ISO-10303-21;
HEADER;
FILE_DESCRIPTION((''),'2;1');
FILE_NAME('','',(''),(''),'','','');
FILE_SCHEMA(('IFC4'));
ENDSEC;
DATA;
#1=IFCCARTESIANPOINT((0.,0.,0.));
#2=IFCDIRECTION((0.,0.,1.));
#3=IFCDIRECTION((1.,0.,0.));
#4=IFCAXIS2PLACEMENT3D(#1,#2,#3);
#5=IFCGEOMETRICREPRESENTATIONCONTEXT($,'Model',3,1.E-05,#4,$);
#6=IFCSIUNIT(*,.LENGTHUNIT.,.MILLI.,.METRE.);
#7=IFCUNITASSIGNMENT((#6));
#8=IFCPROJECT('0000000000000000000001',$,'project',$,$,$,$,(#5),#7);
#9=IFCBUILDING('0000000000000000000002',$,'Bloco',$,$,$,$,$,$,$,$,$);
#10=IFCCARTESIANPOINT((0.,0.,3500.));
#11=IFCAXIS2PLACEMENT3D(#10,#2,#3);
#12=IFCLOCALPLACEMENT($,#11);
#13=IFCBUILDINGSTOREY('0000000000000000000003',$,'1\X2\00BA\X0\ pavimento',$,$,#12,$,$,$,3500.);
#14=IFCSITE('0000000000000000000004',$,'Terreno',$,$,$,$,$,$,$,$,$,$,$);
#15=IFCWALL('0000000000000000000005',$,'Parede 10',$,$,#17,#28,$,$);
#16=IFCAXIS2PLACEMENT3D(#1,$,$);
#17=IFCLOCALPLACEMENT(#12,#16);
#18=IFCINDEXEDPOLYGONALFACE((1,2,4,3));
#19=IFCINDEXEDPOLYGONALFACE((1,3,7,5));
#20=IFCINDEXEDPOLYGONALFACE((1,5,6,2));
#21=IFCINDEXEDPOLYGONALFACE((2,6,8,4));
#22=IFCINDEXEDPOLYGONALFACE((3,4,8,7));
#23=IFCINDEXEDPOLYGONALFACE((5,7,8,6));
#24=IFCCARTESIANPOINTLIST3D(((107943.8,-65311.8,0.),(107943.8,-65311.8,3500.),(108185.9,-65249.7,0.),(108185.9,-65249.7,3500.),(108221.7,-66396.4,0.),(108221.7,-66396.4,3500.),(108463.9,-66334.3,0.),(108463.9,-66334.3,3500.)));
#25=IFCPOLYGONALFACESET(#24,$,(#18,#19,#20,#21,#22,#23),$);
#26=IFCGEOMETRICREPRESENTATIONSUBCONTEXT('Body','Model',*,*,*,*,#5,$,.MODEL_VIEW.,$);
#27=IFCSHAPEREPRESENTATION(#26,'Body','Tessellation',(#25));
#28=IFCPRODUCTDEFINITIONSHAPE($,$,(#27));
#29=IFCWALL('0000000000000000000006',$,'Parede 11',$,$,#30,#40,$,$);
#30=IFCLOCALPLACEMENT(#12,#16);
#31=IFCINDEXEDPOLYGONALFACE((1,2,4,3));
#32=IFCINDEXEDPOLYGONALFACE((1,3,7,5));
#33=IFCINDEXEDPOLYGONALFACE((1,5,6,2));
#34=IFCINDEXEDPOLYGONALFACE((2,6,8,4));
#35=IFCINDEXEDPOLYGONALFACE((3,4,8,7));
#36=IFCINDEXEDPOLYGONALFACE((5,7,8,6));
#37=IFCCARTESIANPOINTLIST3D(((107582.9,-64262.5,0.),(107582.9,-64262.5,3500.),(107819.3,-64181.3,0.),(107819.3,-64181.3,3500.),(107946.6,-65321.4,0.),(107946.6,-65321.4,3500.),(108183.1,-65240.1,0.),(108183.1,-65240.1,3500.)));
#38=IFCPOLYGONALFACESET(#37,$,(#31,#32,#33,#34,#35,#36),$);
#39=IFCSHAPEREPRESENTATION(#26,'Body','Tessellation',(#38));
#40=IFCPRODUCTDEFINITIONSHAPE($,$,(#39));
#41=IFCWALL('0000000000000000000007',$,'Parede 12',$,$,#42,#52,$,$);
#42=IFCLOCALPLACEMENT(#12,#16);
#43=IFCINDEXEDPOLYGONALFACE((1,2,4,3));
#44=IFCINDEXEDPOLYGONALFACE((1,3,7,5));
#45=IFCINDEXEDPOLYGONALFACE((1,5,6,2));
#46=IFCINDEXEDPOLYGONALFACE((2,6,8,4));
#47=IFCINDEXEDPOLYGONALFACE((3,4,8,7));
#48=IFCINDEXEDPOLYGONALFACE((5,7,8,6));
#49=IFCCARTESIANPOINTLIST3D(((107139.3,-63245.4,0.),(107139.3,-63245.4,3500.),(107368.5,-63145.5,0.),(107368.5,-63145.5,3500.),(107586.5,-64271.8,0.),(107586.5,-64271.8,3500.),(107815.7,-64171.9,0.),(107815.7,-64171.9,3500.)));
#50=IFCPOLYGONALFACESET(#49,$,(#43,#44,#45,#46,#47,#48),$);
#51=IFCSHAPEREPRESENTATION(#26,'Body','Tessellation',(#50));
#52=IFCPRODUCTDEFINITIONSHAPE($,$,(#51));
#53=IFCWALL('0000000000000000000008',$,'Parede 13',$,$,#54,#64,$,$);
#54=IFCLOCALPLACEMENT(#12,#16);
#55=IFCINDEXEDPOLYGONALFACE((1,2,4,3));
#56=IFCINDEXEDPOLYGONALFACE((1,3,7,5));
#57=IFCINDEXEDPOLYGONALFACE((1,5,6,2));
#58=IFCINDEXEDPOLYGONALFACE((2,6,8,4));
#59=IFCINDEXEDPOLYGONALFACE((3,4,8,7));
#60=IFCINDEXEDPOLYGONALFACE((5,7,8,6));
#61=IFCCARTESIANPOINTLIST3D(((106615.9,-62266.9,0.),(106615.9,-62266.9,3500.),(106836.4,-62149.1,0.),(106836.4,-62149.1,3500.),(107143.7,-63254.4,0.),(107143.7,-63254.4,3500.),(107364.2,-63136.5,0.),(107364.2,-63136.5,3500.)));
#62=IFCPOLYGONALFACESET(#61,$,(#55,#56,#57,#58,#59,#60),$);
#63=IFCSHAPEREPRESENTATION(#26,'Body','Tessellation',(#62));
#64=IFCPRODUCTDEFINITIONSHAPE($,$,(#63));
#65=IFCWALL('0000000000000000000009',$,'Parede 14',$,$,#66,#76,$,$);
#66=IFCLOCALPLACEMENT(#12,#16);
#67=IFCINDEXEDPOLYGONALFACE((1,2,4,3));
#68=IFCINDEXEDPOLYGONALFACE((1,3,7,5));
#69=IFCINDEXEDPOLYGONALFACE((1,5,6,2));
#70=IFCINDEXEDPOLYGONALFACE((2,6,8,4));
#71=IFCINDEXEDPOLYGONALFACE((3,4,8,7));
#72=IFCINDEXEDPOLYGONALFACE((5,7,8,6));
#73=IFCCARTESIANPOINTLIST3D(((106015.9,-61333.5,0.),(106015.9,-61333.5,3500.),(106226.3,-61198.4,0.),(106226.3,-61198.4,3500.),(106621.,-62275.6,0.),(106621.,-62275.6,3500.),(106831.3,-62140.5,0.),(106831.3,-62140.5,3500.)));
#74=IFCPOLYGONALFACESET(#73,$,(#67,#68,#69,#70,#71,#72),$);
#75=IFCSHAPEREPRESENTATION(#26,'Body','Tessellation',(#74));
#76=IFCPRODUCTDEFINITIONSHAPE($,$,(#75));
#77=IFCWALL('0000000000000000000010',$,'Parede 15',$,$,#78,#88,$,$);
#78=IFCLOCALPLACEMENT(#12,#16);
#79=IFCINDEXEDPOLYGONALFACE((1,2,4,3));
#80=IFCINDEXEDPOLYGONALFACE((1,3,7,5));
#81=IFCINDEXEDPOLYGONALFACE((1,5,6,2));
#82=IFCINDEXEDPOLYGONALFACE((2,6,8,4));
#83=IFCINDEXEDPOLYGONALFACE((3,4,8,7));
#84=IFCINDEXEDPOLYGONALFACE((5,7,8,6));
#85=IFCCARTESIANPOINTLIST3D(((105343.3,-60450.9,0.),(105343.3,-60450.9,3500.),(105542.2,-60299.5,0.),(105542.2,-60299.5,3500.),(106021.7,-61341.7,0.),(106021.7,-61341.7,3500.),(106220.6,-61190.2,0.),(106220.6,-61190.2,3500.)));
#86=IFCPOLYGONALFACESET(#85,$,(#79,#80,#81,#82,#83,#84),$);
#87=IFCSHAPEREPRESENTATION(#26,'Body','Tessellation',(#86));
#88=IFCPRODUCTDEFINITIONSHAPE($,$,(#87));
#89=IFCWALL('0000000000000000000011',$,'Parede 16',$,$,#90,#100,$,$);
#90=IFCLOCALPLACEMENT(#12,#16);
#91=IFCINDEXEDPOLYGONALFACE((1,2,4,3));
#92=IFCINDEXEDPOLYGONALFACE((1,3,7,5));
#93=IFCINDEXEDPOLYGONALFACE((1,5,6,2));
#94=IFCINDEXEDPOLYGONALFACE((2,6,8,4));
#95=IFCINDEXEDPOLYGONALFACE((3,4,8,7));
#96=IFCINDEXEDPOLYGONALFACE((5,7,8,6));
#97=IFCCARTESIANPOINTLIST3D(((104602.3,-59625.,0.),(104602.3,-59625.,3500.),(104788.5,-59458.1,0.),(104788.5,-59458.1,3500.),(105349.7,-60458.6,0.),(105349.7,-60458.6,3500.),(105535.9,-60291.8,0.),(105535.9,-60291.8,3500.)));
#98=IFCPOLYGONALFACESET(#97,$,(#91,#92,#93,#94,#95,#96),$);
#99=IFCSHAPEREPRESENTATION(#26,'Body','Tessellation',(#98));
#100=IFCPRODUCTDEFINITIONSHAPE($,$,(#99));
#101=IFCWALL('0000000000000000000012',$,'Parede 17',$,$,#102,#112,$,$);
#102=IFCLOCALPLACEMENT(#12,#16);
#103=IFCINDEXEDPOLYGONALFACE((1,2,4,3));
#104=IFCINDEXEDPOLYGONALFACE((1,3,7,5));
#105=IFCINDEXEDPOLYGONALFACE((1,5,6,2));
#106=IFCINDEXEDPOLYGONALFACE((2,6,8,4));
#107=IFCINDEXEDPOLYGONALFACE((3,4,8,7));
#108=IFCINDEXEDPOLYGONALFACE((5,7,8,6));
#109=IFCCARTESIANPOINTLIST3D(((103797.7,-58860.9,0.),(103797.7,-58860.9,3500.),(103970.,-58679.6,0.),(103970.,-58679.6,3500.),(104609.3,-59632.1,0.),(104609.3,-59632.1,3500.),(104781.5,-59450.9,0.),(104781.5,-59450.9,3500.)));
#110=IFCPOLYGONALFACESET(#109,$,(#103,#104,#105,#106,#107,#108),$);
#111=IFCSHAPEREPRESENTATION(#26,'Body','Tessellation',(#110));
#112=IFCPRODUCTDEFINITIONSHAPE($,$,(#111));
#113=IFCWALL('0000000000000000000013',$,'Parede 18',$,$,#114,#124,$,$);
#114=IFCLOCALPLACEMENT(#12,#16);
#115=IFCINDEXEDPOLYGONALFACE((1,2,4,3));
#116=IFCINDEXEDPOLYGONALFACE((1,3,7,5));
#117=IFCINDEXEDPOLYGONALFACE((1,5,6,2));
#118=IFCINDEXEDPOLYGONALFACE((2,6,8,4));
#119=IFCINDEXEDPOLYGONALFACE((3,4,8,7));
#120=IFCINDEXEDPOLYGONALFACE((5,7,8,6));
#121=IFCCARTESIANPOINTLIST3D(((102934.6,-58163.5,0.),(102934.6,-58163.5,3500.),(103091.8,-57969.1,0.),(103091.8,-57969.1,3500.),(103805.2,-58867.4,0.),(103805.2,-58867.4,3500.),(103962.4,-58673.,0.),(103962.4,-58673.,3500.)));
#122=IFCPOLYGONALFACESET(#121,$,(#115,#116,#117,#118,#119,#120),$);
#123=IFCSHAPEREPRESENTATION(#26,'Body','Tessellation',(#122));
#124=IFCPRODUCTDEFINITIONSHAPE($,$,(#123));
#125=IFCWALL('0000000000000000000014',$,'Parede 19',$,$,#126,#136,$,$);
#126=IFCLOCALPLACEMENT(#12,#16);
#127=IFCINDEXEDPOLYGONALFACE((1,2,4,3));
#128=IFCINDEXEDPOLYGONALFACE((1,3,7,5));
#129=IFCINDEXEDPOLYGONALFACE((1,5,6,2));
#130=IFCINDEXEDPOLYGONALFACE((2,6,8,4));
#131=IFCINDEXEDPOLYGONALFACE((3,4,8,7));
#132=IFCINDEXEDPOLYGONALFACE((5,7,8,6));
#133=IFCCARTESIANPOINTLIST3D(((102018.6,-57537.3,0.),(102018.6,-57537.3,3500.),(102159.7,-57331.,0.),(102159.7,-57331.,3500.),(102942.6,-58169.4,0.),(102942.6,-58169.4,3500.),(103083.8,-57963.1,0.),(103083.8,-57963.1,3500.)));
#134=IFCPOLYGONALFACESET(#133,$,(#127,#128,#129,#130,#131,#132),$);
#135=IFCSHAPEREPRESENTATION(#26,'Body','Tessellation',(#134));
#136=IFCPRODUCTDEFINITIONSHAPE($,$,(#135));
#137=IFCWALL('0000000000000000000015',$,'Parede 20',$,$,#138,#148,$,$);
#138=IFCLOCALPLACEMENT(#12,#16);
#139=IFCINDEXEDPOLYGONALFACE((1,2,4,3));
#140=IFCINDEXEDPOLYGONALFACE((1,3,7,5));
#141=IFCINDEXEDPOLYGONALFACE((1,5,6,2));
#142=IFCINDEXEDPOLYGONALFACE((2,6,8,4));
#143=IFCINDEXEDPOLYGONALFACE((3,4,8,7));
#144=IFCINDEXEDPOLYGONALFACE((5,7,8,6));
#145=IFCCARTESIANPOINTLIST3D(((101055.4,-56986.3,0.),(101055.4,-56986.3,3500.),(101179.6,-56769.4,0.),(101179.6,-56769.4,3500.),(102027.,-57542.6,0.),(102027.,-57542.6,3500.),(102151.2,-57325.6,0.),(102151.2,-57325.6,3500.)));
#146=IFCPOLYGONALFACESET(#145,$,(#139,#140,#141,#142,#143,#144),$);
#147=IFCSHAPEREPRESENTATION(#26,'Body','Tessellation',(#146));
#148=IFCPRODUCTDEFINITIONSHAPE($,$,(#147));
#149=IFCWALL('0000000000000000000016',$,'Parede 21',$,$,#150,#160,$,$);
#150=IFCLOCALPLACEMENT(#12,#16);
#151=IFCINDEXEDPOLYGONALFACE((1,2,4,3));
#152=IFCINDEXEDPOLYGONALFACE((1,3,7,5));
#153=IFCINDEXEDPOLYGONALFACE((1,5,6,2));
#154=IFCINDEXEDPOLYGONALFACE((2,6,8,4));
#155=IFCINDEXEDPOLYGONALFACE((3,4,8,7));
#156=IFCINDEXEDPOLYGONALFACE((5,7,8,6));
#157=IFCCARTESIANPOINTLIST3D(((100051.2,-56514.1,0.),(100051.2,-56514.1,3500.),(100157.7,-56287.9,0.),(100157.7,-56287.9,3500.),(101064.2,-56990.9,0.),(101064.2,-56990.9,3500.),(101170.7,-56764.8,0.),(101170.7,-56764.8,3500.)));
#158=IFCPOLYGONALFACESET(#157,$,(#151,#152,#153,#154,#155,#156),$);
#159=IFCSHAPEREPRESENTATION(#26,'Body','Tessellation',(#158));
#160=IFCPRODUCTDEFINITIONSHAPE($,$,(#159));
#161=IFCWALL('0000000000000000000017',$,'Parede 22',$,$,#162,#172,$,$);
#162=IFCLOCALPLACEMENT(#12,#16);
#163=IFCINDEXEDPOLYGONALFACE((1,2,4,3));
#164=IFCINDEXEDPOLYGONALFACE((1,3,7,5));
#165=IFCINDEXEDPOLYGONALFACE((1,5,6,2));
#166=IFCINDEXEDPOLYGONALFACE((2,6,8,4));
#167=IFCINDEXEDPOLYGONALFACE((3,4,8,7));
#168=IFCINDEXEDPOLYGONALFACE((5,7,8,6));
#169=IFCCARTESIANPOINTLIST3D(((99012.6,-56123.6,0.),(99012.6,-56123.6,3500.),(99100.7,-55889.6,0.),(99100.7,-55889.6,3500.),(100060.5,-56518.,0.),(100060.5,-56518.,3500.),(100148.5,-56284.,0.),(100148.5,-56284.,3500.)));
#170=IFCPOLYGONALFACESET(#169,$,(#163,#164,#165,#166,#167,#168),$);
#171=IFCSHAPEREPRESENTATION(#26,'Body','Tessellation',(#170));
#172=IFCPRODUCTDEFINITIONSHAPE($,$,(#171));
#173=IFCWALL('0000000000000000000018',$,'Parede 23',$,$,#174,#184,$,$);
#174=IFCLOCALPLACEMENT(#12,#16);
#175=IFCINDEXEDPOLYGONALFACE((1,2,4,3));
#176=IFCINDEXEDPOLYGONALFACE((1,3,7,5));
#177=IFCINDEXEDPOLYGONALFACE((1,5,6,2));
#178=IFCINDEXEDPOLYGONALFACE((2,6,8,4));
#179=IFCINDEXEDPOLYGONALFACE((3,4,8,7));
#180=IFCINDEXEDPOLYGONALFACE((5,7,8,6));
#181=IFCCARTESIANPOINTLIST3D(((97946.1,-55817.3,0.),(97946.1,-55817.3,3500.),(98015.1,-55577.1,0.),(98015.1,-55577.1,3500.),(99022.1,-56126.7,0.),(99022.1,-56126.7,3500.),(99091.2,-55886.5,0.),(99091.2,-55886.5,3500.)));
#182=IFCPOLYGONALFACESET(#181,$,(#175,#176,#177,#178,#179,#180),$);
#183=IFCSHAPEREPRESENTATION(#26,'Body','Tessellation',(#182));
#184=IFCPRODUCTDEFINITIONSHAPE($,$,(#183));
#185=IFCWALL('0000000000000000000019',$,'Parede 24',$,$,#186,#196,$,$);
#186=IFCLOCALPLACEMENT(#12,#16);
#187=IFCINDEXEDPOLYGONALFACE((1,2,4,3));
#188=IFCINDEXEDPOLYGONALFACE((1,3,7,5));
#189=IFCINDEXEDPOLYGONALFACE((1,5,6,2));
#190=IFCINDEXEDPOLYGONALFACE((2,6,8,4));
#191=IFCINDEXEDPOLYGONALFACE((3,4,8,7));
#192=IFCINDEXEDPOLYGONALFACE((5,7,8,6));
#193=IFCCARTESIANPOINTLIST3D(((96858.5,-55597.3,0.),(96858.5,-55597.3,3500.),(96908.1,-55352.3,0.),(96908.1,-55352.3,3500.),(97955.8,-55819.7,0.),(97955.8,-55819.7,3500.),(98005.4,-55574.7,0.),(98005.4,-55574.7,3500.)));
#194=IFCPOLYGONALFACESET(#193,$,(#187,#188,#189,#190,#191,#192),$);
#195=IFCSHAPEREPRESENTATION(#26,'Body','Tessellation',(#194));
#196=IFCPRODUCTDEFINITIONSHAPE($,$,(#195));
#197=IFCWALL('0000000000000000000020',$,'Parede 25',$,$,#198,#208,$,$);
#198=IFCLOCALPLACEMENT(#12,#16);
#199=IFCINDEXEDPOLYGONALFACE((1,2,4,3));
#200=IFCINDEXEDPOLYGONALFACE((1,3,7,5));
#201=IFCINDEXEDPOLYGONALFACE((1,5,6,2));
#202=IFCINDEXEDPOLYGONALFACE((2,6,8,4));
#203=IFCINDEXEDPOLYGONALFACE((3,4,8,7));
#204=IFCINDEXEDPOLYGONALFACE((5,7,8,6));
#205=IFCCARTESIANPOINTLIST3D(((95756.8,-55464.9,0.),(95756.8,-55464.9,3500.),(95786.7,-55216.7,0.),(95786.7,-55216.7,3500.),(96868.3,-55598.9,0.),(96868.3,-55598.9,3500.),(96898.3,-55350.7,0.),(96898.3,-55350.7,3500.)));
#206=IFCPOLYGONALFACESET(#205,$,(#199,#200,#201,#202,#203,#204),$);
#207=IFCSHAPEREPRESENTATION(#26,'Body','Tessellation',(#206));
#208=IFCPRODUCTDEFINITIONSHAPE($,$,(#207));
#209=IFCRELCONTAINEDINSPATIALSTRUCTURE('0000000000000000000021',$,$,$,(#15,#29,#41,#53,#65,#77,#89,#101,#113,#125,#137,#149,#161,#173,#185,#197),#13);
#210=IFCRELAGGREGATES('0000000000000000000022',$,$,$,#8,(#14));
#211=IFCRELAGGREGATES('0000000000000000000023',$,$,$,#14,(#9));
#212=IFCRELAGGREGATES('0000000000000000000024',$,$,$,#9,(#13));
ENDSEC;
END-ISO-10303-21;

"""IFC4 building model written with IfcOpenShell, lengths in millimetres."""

from ifc_helpers import new_model, si_unit, frame, origin, origin_with_axes, place, context, subcontext, project, spatial, polyline, outline, extrude, element, save


model = new_model("IFC4")

# Units and contexts
model_context = context("Model", 3, precision=1e-05, world=origin_with_axes())
body_context = subcontext(model_context, "Body", "Model", "MODEL_VIEW")
ifc_project = project(units=[si_unit("LENGTHUNIT", "METRE", prefix="MILLI")], contexts=[model_context])

# Site, building, storey
site = spatial("IfcSite", under=ifc_project, Name="Terreno")
building = spatial("IfcBuilding", under=site, Name="Bloco")
storey_placement = place(None, frame((0.0, 0.0, 3500.0), z_axis=(0.0, 0.0, 1.0), x_axis=(1.0, 0.0, 0.0)))
storey = spatial("IfcBuildingStorey", under=building, at=storey_placement, Name="1º pavimento", Elevation=3500.0)

# Walls
wall_1_placement = place(storey_placement, origin_with_axes())
element("IfcWall", 1, at=wall_1_placement, inside=storey, Name="Parede 10", context=body_context, shape_type="SweptSolid", body=[
    extrude(outline(polyline([(108221.7, -66396.4), (107943.8, -65311.8), (108185.9, -65249.7), (108463.9, -66334.3), (108221.7, -66396.4)])), origin(), (0.0, 0.0, 1.0), 3500.0),
])
wall_2_placement = place(storey_placement, origin_with_axes())
element("IfcWall", 2, at=wall_2_placement, inside=storey, Name="Parede 11", context=body_context, shape_type="SweptSolid", body=[
    extrude(outline(polyline([(107946.6, -65321.4), (107582.9, -64262.5), (107819.3, -64181.3), (108183.1, -65240.1), (107946.6, -65321.4)])), origin(), (0.0, 0.0, 1.0), 3500.0),
])
wall_3_placement = place(storey_placement, origin_with_axes())
element("IfcWall", 3, at=wall_3_placement, inside=storey, Name="Parede 12", context=body_context, shape_type="SweptSolid", body=[
    extrude(outline(polyline([(107586.5, -64271.8), (107139.3, -63245.4), (107368.5, -63145.5), (107815.7, -64171.9), (107586.5, -64271.8)])), origin(), (0.0, 0.0, 1.0), 3500.0),
])
wall_4_placement = place(storey_placement, origin_with_axes())
element("IfcWall", 4, at=wall_4_placement, inside=storey, Name="Parede 13", context=body_context, shape_type="SweptSolid", body=[
    extrude(outline(polyline([(107143.7, -63254.4), (106615.9, -62266.9), (106836.4, -62149.1), (107364.2, -63136.5), (107143.7, -63254.4)])), origin(), (0.0, 0.0, 1.0), 3500.0),
])
wall_5_placement = place(storey_placement, origin_with_axes())
element("IfcWall", 5, at=wall_5_placement, inside=storey, Name="Parede 14", context=body_context, shape_type="SweptSolid", body=[
    extrude(outline(polyline([(106621.0, -62275.6), (106015.9, -61333.5), (106226.3, -61198.4), (106831.3, -62140.5), (106621.0, -62275.6)])), origin(), (0.0, 0.0, 1.0), 3500.0),
])
wall_6_placement = place(storey_placement, origin_with_axes())
element("IfcWall", 6, at=wall_6_placement, inside=storey, Name="Parede 15", context=body_context, shape_type="SweptSolid", body=[
    extrude(outline(polyline([(106021.7, -61341.7), (105343.3, -60450.9), (105542.2, -60299.5), (106220.6, -61190.2), (106021.7, -61341.7)])), origin(), (0.0, 0.0, 1.0), 3500.0),
])
wall_7_placement = place(storey_placement, origin_with_axes())
element("IfcWall", 7, at=wall_7_placement, inside=storey, Name="Parede 16", context=body_context, shape_type="SweptSolid", body=[
    extrude(outline(polyline([(105349.7, -60458.6), (104602.3, -59625.0), (104788.5, -59458.1), (105535.9, -60291.8), (105349.7, -60458.6)])), origin(), (0.0, 0.0, 1.0), 3500.0),
])
wall_8_placement = place(storey_placement, origin_with_axes())
element("IfcWall", 8, at=wall_8_placement, inside=storey, Name="Parede 17", context=body_context, shape_type="SweptSolid", body=[
    extrude(outline(polyline([(104609.3, -59632.1), (103797.7, -58860.9), (103970.0, -58679.6), (104781.5, -59450.9), (104609.3, -59632.1)])), origin(), (0.0, 0.0, 1.0), 3500.0),
])
wall_9_placement = place(storey_placement, origin_with_axes())
element("IfcWall", 9, at=wall_9_placement, inside=storey, Name="Parede 18", context=body_context, shape_type="SweptSolid", body=[
    extrude(outline(polyline([(103805.2, -58867.4), (102934.6, -58163.5), (103091.8, -57969.1), (103962.4, -58673.0), (103805.2, -58867.4)])), origin(), (0.0, 0.0, 1.0), 3500.0),
])
wall_10_placement = place(storey_placement, origin_with_axes())
element("IfcWall", 10, at=wall_10_placement, inside=storey, Name="Parede 19", context=body_context, shape_type="SweptSolid", body=[
    extrude(outline(polyline([(102942.6, -58169.4), (102018.6, -57537.3), (102159.7, -57331.0), (103083.8, -57963.1), (102942.6, -58169.4)])), origin(), (0.0, 0.0, 1.0), 3500.0),
])
wall_11_placement = place(storey_placement, origin_with_axes())
element("IfcWall", 11, at=wall_11_placement, inside=storey, Name="Parede 20", context=body_context, shape_type="SweptSolid", body=[
    extrude(outline(polyline([(102027.0, -57542.6), (101055.4, -56986.3), (101179.6, -56769.4), (102151.2, -57325.6), (102027.0, -57542.6)])), origin(), (0.0, 0.0, 1.0), 3500.0),
])
wall_12_placement = place(storey_placement, origin_with_axes())
element("IfcWall", 12, at=wall_12_placement, inside=storey, Name="Parede 21", context=body_context, shape_type="SweptSolid", body=[
    extrude(outline(polyline([(101064.2, -56990.9), (100051.2, -56514.1), (100157.7, -56287.9), (101170.7, -56764.8), (101064.2, -56990.9)])), origin(), (0.0, 0.0, 1.0), 3500.0),
])
wall_13_placement = place(storey_placement, origin_with_axes())
element("IfcWall", 13, at=wall_13_placement, inside=storey, Name="Parede 22", context=body_context, shape_type="SweptSolid", body=[
    extrude(outline(polyline([(100060.5, -56518.0), (99012.6, -56123.6), (99100.7, -55889.6), (100148.5, -56284.0), (100060.5, -56518.0)])), origin(), (0.0, 0.0, 1.0), 3500.0),
])
wall_14_placement = place(storey_placement, origin_with_axes())
element("IfcWall", 14, at=wall_14_placement, inside=storey, Name="Parede 23", context=body_context, shape_type="SweptSolid", body=[
    extrude(outline(polyline([(99022.1, -56126.7), (97946.1, -55817.3), (98015.1, -55577.1), (99091.2, -55886.5), (99022.1, -56126.7)])), origin(), (0.0, 0.0, 1.0), 3500.0),
])
wall_15_placement = place(storey_placement, origin_with_axes())
element("IfcWall", 15, at=wall_15_placement, inside=storey, Name="Parede 24", context=body_context, shape_type="SweptSolid", body=[
    extrude(outline(polyline([(97955.8, -55819.7), (96858.5, -55597.3), (96908.1, -55352.3), (98005.4, -55574.7), (97955.8, -55819.7)])), origin(), (0.0, 0.0, 1.0), 3500.0),
])
wall_16_placement = place(storey_placement, origin_with_axes())
element("IfcWall", 16, at=wall_16_placement, inside=storey, Name="Parede 25", context=body_context, shape_type="SweptSolid", body=[
    extrude(outline(polyline([(96868.3, -55598.9), (95756.8, -55464.9), (95786.7, -55216.7), (96898.3, -55350.7), (96868.3, -55598.9)])), origin(), (0.0, 0.0, 1.0), 3500.0),
])

save(model, "model.ifc")
